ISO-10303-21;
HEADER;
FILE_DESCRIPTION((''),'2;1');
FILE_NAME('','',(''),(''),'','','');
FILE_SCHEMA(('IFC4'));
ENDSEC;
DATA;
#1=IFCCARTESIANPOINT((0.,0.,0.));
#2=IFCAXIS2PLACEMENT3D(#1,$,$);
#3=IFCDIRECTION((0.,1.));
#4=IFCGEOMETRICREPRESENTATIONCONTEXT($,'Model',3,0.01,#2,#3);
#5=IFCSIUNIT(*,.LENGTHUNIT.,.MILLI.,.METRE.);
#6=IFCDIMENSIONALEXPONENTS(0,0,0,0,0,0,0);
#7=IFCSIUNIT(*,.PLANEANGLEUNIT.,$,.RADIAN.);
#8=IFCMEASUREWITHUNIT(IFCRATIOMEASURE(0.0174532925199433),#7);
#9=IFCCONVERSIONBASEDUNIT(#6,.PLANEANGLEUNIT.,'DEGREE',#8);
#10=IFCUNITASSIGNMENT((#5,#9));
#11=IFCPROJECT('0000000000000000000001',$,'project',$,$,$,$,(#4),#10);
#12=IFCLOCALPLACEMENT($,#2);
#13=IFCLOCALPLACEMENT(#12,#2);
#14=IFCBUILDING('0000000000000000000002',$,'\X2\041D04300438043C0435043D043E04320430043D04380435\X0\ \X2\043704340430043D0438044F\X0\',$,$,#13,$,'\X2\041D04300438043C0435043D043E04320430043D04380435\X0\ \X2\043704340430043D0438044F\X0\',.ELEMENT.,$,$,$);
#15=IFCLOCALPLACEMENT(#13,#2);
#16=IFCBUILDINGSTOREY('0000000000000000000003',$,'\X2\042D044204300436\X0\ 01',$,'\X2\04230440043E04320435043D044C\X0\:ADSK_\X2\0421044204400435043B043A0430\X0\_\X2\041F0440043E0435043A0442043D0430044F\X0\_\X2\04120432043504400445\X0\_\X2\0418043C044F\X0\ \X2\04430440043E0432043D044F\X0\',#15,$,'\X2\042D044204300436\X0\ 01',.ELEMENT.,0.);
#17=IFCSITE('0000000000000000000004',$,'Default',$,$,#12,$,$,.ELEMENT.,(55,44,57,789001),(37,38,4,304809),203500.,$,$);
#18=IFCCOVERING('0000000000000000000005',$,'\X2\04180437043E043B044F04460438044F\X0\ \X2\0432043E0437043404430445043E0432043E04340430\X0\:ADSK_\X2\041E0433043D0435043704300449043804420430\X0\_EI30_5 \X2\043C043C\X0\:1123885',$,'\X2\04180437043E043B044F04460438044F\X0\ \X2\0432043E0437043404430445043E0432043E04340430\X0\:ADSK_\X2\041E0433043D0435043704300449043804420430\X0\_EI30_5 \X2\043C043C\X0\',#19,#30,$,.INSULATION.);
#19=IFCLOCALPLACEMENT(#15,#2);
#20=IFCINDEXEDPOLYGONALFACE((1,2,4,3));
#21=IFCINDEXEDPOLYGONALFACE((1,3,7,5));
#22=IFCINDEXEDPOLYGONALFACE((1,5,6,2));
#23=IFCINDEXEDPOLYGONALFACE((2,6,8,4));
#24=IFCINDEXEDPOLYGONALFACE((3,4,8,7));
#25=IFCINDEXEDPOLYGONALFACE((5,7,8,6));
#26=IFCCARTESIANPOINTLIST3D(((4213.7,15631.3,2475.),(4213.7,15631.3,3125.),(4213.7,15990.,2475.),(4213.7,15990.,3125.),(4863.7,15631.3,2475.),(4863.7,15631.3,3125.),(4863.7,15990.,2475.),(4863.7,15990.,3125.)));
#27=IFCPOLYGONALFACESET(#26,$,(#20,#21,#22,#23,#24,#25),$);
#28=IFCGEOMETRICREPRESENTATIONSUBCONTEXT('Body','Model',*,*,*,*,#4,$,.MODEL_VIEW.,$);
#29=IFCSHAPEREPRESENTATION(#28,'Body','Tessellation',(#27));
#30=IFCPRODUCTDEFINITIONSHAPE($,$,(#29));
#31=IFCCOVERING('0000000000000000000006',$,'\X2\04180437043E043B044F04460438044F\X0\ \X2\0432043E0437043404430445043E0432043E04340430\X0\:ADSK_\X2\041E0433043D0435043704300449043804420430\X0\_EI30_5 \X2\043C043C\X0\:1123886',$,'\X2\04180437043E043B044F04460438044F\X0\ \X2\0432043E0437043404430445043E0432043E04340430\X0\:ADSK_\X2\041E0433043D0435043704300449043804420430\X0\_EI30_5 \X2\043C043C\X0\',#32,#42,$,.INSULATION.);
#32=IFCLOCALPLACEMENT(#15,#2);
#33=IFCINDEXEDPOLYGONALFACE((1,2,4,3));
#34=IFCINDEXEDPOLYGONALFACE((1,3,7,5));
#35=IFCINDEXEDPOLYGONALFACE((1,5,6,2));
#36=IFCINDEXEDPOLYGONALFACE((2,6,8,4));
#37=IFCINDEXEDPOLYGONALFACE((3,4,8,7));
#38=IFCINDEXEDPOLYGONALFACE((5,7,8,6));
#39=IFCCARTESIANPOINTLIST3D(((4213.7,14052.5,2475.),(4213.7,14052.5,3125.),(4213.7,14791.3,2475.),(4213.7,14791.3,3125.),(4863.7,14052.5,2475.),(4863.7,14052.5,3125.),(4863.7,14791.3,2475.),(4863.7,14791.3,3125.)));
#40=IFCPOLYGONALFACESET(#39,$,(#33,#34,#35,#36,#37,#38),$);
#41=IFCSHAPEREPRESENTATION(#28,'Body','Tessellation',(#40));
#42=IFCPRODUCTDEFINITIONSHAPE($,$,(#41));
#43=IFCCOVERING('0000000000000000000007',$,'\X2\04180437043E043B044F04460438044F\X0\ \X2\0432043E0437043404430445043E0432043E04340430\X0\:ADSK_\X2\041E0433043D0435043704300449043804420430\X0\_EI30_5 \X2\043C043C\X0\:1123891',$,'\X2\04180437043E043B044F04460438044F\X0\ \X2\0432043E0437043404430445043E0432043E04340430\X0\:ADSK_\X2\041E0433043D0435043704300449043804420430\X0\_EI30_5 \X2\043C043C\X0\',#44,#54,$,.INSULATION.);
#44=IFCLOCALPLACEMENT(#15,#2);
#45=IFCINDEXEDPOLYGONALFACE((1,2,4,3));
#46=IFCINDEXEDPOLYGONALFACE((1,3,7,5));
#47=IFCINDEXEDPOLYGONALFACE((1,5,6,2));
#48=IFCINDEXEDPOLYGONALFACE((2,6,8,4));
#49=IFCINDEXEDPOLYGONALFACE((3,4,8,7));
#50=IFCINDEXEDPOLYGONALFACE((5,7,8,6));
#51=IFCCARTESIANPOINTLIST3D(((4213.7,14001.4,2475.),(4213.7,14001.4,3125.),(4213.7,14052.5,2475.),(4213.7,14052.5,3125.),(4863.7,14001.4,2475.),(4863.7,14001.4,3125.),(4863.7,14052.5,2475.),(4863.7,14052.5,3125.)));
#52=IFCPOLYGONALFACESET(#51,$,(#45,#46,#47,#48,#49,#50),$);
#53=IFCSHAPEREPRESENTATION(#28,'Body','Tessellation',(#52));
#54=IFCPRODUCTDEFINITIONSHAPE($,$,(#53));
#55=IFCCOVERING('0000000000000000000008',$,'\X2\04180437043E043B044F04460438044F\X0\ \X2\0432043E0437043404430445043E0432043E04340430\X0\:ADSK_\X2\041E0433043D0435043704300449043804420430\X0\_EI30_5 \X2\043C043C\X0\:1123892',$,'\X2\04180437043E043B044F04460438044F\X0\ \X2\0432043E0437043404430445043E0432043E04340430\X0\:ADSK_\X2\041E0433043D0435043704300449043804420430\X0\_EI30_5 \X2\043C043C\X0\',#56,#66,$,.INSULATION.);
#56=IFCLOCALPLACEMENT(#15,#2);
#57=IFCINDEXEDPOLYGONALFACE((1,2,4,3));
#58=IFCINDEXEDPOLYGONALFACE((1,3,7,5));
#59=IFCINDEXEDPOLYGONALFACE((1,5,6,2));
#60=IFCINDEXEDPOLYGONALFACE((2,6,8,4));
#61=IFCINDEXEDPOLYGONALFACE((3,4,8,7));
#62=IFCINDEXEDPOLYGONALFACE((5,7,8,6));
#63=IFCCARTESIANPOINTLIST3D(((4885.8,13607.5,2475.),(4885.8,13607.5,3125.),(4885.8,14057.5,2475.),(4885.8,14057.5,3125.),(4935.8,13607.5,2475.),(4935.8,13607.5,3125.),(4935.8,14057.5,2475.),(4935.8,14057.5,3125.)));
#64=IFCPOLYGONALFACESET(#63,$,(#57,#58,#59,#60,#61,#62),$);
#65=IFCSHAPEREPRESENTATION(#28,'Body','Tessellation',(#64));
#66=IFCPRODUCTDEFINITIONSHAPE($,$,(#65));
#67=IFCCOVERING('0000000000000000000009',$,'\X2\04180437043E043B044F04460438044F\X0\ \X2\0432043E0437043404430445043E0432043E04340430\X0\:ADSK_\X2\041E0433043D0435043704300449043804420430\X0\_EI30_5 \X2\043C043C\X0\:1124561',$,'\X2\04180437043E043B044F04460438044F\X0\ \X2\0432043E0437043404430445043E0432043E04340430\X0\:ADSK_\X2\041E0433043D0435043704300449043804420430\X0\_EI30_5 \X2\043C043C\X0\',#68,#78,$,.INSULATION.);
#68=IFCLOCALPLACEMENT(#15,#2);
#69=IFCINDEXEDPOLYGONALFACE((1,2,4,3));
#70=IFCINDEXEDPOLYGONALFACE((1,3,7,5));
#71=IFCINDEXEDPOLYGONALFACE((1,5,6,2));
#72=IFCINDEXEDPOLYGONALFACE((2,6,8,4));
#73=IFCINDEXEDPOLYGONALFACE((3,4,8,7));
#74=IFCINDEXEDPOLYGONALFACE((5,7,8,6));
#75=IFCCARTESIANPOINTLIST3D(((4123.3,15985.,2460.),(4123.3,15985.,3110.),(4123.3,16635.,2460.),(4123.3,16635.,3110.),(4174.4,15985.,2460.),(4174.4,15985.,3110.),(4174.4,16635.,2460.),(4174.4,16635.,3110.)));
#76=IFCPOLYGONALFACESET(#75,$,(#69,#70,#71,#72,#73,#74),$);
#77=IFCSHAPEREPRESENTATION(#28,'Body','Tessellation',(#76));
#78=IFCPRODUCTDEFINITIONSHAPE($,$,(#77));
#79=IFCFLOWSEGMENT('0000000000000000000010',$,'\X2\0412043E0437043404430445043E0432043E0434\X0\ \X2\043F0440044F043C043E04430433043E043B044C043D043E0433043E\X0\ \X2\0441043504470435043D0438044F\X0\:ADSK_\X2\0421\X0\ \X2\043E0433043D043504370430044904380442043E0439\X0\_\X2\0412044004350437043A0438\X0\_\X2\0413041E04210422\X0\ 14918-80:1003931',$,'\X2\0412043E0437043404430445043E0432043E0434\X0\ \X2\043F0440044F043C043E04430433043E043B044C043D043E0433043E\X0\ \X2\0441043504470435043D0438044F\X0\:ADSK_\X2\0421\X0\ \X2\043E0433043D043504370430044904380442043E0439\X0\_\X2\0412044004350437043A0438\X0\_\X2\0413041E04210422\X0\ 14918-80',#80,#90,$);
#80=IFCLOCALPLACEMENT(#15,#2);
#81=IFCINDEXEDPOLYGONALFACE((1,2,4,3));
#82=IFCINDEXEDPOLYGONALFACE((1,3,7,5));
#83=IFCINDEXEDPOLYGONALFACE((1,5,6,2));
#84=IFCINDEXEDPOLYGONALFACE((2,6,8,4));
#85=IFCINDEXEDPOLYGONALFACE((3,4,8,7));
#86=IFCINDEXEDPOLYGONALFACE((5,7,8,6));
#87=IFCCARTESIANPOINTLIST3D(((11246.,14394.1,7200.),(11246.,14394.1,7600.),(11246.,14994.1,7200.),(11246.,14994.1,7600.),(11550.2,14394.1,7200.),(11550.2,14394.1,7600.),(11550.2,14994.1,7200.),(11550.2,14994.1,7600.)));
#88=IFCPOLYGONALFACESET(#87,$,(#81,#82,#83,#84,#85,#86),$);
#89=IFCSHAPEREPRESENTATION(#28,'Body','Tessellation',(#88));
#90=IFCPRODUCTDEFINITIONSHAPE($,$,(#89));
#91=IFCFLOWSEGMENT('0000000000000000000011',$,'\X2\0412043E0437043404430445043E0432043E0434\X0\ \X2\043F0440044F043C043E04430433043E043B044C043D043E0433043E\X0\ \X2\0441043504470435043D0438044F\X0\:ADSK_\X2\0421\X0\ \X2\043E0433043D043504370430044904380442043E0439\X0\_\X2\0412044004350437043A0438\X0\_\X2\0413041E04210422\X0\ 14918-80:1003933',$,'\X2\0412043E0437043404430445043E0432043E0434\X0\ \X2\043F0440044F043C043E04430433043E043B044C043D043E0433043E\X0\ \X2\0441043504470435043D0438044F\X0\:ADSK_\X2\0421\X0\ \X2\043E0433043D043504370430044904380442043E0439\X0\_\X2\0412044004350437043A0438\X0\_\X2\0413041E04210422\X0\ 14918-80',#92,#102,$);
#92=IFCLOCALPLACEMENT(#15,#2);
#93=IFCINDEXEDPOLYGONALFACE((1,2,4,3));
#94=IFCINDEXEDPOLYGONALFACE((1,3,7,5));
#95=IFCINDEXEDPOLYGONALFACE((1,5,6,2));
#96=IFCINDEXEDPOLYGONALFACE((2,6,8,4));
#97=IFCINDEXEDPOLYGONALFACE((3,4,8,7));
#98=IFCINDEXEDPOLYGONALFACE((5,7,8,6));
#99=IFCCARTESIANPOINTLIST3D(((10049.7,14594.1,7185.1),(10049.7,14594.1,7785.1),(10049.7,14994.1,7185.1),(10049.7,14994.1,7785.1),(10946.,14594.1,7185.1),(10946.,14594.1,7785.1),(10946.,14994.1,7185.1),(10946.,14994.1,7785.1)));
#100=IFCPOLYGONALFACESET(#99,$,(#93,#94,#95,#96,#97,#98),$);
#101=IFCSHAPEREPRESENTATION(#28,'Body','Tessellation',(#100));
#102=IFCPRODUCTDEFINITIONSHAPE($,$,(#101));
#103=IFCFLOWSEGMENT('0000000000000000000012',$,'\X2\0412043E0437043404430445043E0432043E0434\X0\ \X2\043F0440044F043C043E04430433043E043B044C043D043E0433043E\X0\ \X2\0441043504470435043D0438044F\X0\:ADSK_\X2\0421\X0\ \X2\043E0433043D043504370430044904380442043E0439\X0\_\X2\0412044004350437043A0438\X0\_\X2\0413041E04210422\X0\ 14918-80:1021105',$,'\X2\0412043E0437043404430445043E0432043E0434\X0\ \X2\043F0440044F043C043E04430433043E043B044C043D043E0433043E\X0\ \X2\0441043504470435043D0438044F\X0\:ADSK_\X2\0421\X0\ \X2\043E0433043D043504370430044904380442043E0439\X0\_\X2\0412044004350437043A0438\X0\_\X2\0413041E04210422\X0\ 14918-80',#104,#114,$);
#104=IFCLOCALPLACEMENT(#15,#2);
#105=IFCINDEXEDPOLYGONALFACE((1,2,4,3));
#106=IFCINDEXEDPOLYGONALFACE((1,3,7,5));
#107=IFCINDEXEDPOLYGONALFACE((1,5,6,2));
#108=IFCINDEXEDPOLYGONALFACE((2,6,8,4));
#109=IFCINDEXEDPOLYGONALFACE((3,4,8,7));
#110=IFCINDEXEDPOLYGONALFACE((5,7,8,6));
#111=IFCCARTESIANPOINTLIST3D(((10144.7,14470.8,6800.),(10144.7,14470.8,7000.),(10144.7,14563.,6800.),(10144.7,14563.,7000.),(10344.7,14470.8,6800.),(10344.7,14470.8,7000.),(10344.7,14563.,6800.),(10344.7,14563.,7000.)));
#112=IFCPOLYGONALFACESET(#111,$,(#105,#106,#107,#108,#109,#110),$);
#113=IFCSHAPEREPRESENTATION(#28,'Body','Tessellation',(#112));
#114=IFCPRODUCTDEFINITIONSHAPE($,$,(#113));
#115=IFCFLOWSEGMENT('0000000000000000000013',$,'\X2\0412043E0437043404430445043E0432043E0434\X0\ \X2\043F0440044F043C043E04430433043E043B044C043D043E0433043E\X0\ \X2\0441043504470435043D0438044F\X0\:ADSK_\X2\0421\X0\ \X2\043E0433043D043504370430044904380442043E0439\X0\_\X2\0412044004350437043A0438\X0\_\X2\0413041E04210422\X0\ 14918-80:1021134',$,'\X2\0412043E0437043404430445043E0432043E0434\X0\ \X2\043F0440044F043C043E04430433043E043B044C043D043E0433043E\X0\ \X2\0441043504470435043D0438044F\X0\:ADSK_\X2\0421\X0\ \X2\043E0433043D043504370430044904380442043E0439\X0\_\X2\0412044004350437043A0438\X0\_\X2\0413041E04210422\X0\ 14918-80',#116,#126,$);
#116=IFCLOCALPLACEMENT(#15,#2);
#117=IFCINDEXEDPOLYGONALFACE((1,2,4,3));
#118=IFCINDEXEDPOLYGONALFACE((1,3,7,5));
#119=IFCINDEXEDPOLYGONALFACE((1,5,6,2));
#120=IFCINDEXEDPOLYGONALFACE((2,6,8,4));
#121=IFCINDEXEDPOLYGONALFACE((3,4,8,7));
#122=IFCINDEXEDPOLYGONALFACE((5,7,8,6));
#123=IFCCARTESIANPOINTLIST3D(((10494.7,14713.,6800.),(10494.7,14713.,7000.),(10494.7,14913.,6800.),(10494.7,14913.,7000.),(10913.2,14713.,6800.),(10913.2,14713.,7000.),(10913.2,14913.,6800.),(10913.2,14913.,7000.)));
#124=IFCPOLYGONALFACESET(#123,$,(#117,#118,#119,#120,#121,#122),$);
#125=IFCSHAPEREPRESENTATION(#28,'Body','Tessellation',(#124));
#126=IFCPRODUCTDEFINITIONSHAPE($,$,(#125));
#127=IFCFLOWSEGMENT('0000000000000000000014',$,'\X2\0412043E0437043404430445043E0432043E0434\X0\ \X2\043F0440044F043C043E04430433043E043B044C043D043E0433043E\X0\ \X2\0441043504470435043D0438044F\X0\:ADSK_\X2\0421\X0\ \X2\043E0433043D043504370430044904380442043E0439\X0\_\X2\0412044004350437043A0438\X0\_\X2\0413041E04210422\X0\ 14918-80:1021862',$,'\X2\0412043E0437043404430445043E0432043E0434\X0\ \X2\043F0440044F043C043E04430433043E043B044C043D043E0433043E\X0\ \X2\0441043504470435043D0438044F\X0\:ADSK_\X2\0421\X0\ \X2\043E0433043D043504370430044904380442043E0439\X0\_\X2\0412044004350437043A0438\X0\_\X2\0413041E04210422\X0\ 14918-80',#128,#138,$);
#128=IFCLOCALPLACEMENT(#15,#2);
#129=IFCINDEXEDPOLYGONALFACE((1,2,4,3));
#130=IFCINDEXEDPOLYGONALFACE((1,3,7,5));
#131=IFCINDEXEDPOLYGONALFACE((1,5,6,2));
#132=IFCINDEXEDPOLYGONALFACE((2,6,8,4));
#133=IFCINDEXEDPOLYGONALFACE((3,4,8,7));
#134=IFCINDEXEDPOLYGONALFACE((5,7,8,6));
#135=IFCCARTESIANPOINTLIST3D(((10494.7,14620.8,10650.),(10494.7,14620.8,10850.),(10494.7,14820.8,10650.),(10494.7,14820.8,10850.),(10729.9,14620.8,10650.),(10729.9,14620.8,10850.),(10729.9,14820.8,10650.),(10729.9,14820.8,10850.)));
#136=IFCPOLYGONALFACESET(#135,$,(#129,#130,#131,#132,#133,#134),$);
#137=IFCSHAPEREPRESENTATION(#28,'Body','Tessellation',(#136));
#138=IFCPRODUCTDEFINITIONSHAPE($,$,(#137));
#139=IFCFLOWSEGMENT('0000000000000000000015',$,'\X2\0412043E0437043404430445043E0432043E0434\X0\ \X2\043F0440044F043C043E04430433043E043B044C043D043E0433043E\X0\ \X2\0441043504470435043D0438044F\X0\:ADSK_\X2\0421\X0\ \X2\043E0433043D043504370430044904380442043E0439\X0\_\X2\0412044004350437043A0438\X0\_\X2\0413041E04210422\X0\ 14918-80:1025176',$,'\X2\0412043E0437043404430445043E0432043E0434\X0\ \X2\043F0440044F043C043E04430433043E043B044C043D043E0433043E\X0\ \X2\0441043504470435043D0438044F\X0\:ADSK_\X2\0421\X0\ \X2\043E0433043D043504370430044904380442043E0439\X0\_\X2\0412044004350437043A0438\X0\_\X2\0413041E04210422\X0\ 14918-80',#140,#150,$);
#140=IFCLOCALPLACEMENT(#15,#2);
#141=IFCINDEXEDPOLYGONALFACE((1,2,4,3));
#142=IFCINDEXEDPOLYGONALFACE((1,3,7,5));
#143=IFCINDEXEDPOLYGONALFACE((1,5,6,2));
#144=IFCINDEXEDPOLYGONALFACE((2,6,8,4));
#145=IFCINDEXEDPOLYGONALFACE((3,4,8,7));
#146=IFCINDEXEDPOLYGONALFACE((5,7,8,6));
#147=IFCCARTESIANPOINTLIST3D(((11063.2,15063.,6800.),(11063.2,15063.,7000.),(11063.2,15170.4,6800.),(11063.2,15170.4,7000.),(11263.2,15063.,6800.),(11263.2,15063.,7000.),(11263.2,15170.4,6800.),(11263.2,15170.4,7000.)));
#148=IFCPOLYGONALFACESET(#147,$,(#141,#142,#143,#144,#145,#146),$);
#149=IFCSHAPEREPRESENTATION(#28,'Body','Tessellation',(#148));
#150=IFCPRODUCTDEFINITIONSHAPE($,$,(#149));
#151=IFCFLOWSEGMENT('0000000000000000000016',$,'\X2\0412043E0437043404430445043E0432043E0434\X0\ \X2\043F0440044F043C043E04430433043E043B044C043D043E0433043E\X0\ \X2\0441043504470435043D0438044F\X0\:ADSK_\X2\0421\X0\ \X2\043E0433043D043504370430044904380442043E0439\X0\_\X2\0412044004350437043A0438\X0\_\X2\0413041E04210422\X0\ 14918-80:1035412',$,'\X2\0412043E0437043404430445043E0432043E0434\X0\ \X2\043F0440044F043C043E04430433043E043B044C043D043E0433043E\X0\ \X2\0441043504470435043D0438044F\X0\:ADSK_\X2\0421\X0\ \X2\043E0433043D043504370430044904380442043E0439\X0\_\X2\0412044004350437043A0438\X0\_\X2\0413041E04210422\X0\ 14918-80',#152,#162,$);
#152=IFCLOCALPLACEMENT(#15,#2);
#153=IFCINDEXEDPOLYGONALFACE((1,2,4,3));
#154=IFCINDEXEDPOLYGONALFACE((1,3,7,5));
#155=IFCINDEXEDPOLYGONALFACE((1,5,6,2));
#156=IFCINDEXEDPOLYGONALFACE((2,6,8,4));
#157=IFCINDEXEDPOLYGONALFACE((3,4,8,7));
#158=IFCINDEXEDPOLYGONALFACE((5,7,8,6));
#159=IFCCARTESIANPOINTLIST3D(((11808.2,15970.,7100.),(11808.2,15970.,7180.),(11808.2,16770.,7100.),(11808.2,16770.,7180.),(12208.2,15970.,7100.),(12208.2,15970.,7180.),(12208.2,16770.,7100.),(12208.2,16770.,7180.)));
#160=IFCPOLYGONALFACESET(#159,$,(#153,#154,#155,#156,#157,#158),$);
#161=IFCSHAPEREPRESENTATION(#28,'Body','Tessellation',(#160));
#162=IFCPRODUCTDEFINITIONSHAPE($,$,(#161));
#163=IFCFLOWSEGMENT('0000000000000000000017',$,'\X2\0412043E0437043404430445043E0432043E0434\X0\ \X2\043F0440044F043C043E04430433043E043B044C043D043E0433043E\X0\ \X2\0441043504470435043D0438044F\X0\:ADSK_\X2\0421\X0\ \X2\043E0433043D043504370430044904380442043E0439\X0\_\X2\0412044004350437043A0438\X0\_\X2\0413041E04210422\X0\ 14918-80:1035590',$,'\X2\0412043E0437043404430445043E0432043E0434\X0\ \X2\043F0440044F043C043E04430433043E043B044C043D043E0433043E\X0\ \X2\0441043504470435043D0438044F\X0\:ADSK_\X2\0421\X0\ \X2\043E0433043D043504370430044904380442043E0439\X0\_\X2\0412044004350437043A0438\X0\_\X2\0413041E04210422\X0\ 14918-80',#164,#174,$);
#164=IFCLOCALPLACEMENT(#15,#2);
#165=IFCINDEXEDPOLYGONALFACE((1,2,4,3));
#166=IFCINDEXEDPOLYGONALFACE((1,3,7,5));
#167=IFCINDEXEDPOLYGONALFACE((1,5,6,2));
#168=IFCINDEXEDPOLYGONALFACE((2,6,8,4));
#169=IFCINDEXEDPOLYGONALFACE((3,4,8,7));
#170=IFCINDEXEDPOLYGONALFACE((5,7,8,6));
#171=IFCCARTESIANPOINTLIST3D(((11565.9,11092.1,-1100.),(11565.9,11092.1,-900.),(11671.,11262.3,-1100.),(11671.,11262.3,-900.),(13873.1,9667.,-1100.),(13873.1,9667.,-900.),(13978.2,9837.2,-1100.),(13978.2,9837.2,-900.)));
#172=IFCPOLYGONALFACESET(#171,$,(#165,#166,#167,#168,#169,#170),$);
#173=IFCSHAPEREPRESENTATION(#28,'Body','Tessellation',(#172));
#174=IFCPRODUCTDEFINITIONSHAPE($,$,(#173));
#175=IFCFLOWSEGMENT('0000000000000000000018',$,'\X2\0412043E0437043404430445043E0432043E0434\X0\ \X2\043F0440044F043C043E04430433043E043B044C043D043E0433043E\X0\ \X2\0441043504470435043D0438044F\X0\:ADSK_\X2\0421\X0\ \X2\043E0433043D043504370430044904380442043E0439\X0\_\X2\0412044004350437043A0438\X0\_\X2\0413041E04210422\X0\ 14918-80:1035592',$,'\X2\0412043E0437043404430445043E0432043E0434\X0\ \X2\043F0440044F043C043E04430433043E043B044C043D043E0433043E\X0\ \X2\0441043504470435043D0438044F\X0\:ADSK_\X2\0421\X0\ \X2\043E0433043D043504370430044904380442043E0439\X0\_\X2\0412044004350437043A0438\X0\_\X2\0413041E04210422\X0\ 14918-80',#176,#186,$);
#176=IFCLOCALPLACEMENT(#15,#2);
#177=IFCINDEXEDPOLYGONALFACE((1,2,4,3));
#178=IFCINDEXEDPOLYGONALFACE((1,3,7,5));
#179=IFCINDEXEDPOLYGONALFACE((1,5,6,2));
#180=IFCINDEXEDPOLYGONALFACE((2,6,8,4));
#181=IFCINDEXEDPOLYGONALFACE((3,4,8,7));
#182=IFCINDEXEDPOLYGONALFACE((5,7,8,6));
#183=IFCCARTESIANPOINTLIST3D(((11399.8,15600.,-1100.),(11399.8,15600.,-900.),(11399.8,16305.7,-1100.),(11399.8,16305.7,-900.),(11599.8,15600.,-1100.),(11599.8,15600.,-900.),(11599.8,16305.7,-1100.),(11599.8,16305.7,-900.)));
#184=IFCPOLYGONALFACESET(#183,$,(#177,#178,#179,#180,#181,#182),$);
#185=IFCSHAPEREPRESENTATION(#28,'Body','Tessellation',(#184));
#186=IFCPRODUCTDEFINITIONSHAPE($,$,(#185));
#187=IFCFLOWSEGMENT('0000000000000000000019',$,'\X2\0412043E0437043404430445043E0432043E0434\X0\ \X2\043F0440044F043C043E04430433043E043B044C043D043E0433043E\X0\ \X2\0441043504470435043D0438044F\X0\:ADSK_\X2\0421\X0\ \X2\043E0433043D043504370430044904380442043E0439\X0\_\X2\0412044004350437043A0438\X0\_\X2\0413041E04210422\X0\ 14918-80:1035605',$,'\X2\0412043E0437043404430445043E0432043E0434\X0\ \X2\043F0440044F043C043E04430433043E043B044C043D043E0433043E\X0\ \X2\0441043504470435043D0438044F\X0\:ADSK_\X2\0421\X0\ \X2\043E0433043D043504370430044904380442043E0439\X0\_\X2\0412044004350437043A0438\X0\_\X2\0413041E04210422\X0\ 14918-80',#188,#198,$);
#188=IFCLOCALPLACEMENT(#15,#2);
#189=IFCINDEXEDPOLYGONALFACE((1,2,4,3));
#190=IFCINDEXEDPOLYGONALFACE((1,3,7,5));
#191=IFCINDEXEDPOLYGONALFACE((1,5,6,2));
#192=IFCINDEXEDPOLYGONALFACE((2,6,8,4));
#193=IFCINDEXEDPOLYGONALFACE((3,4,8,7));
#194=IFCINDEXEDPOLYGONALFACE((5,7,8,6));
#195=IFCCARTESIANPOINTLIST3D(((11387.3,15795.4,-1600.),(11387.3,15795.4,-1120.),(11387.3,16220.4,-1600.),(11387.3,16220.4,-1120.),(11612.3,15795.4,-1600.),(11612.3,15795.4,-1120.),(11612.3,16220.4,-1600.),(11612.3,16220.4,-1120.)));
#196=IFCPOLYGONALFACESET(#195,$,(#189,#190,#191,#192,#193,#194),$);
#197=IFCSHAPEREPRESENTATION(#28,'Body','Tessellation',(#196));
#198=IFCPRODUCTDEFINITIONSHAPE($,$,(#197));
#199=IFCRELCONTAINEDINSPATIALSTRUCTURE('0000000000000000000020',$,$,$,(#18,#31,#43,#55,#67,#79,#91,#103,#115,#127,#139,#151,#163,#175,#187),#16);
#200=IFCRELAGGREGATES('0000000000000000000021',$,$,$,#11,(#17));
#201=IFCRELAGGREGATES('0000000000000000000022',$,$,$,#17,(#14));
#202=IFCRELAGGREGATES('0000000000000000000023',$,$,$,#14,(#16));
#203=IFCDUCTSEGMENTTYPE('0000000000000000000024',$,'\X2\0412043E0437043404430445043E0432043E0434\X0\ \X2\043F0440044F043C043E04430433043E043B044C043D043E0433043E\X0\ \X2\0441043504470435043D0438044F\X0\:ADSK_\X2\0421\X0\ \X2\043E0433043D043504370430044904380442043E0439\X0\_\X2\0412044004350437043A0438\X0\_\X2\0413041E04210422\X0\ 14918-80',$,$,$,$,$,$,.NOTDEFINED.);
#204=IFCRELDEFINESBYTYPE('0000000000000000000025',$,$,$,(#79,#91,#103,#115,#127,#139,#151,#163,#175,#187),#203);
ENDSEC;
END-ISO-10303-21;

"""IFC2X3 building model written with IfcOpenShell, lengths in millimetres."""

from ifc_helpers import new_model, entity, si_unit, converted_unit, direction, frame, frame_2d, origin, origin_2d_with_axis, place, context, subcontext, project, spatial, rectangle, extrude, type_object, element, save


model = new_model("IFC2X3")

# Units and contexts
model_context = context("Model", 3, precision=0.01, world=origin(), true_north=direction((0.0, 1.0)))
body_context = subcontext(model_context, "Body", "Model", "MODEL_VIEW")
ifc_project = project(units=[si_unit("LENGTHUNIT", "METRE", prefix="MILLI"), converted_unit("PLANEANGLEUNIT", "DEGREE", entity("IfcRatioMeasure", 0.0174532925199433), si_unit("PLANEANGLEUNIT", "RADIAN"), dimensions=[0, 0, 0, 0, 0, 0, 0])], contexts=[model_context])

# Site, building, storey
site_placement = place(None, frame((0.0, 0.0, 0.0)))
site = spatial("IfcSite", under=ifc_project, at=site_placement, Name="Default", CompositionType="ELEMENT", RefLatitude=(55, 44, 57, 789001), RefLongitude=(37, 38, 4, 304809), RefElevation=203500.0)
building_placement = place(site_placement, origin())
building = spatial("IfcBuilding", under=site, at=building_placement, Name="Наименование здания", LongName="Наименование здания", CompositionType="ELEMENT")
storey_placement = place(building_placement, origin())
storey = spatial("IfcBuildingStorey", under=building, at=storey_placement, Name="Этаж 01", ObjectType="Уровень:ADSK_Стрелка_Проектная_Вверх_Имя уровня", LongName="Этаж 01", CompositionType="ELEMENT", Elevation=0.0)

# Coverings
covering_1_placement = place(storey_placement, frame((4213.7, 15631.3, 2475.0)))
element("IfcCovering", 1, at=covering_1_placement, inside=storey, Name="Изоляция воздуховода:ADSK_Огнезащита_EI30_5 мм:1123885", ObjectType="Изоляция воздуховода:ADSK_Огнезащита_EI30_5 мм", PredefinedType="INSULATION", context=body_context, shape_type="SweptSolid", body=[
    extrude(rectangle(XDim=358.6, YDim=650.0, at=origin_2d_with_axis()), frame((325.0, 179.3, 0.0), z_axis=(0.0, 0.0, 1.0), x_axis=(0.0, 1.0, 0.0)), (0.0, 0.0, 1.0), 650.0),
])
covering_2_placement = place(storey_placement, frame((4213.7, 14052.5, 2475.0)))
element("IfcCovering", 2, at=covering_2_placement, inside=storey, Name="Изоляция воздуховода:ADSK_Огнезащита_EI30_5 мм:1123886", ObjectType="Изоляция воздуховода:ADSK_Огнезащита_EI30_5 мм", PredefinedType="INSULATION", context=body_context, shape_type="SweptSolid", body=[
    extrude(rectangle(XDim=738.8, YDim=650.0, at=origin_2d_with_axis()), frame((325.0, 369.4, 0.0), z_axis=(0.0, 0.0, 1.0), x_axis=(0.0, -1.0, 0.0)), (0.0, 0.0, 1.0), 650.0),
])
covering_3_placement = place(storey_placement, frame((4213.7, 14001.4, 2475.0)))
element("IfcCovering", 3, at=covering_3_placement, inside=storey, Name="Изоляция воздуховода:ADSK_Огнезащита_EI30_5 мм:1123891", ObjectType="Изоляция воздуховода:ADSK_Огнезащита_EI30_5 мм", PredefinedType="INSULATION", context=body_context, shape_type="SweptSolid", body=[
    extrude(rectangle(XDim=650.0, YDim=51.1, at=frame_2d((0.0, 0.0), x_axis=(1.0, 0.0))), frame((325.0, 25.5, 0.0), z_axis=(0.0, 0.0, 1.0), x_axis=(-1.0, 0.0, 0.0)), (0.0, 0.0, 1.0), 650.0),
])
covering_4_placement = place(storey_placement, frame((4885.8, 13607.5, 2475.0)))
element("IfcCovering", 4, at=covering_4_placement, inside=storey, Name="Изоляция воздуховода:ADSK_Огнезащита_EI30_5 мм:1123892", ObjectType="Изоляция воздуховода:ADSK_Огнезащита_EI30_5 мм", PredefinedType="INSULATION", context=body_context, shape_type="SweptSolid", body=[
    extrude(rectangle(XDim=50.0, YDim=450.0, at=frame_2d((0.0, 0.0), x_axis=(1.0, 0.0))), frame((25.0, 225.0, 0.0), z_axis=(0.0, 0.0, 1.0), x_axis=(-1.0, 0.0, 0.0)), (0.0, 0.0, 1.0), 650.0),
])
covering_5_placement = place(storey_placement, frame((4123.3, 15985.0, 2460.0)))
element("IfcCovering", 5, at=covering_5_placement, inside=storey, Name="Изоляция воздуховода:ADSK_Огнезащита_EI30_5 мм:1124561", ObjectType="Изоляция воздуховода:ADSK_Огнезащита_EI30_5 мм", PredefinedType="INSULATION", context=body_context, shape_type="SweptSolid", body=[
    extrude(rectangle(XDim=650.0, YDim=51.1, at=frame_2d((0.0, 0.0), x_axis=(1.0, 0.0))), frame((25.5, 325.0, 0.0), z_axis=(0.0, 0.0, 1.0), x_axis=(0.0, -1.0, 0.0)), (0.0, 0.0, 1.0), 650.0),
])

# Flow segments
duct_segment_type_1 = type_object("IfcDuctSegmentType", Name="Воздуховод прямоугольного сечения:ADSK_С огнезащитой_Врезки_ГОСТ 14918-80", PredefinedType="NOTDEFINED")
flow_segment_1_placement = place(storey_placement, frame((11246.0, 14394.1, 7200.0)))
element("IfcFlowSegment", 6, at=flow_segment_1_placement, inside=storey, type_object=duct_segment_type_1, Name="Воздуховод прямоугольного сечения:ADSK_С огнезащитой_Врезки_ГОСТ 14918-80:1003931", ObjectType="Воздуховод прямоугольного сечения:ADSK_С огнезащитой_Врезки_ГОСТ 14918-80", context=body_context, shape_type="SweptSolid", body=[
    extrude(rectangle(XDim=304.2, YDim=600.0, at=frame_2d((0.0, 0.0), x_axis=(1.0, 0.0))), frame((152.1, 300.0, 0.0), z_axis=(0.0, 0.0, 1.0), x_axis=(-1.0, 0.0, 0.0)), (0.0, 0.0, 1.0), 400.0),
])
flow_segment_2_placement = place(storey_placement, frame((10049.7, 14594.1, 7185.1)))
element("IfcFlowSegment", 7, at=flow_segment_2_placement, inside=storey, type_object=duct_segment_type_1, Name="Воздуховод прямоугольного сечения:ADSK_С огнезащитой_Врезки_ГОСТ 14918-80:1003933", ObjectType="Воздуховод прямоугольного сечения:ADSK_С огнезащитой_Врезки_ГОСТ 14918-80", context=body_context, shape_type="SweptSolid", body=[
    extrude(rectangle(XDim=896.3, YDim=400.0, at=origin_2d_with_axis()), frame((448.1, 200.0, 0.0), z_axis=(0.0, 0.0, 1.0), x_axis=(-1.0, 0.0, 0.0)), (0.0, 0.0, 1.0), 600.0),
])
flow_segment_3_placement = place(storey_placement, frame((10144.7, 14470.8, 6800.0)))
element("IfcFlowSegment", 8, at=flow_segment_3_placement, inside=storey, type_object=duct_segment_type_1, Name="Воздуховод прямоугольного сечения:ADSK_С огнезащитой_Врезки_ГОСТ 14918-80:1021105", ObjectType="Воздуховод прямоугольного сечения:ADSK_С огнезащитой_Врезки_ГОСТ 14918-80", context=body_context, shape_type="SweptSolid", body=[
    extrude(rectangle(XDim=92.2, YDim=200.0, at=frame_2d((0.0, 0.0), x_axis=(1.0, 0.0))), frame((100.0, 46.1, 0.0), z_axis=(0.0, 0.0, 1.0), x_axis=(0.0, 1.0, 0.0)), (0.0, 0.0, 1.0), 200.0),
])
flow_segment_4_placement = place(storey_placement, frame((10494.7, 14713.0, 6800.0)))
element("IfcFlowSegment", 9, at=flow_segment_4_placement, inside=storey, type_object=duct_segment_type_1, Name="Воздуховод прямоугольного сечения:ADSK_С огнезащитой_Врезки_ГОСТ 14918-80:1021134", ObjectType="Воздуховод прямоугольного сечения:ADSK_С огнезащитой_Врезки_ГОСТ 14918-80", context=body_context, shape_type="SweptSolid", body=[
    extrude(rectangle(XDim=418.5, YDim=200.0, at=frame_2d((0.0, 0.0), x_axis=(1.0, 0.0))), frame((209.3, 100.0, 0.0)), (0.0, 0.0, 1.0), 200.0),
])
flow_segment_5_placement = place(storey_placement, frame((10494.7, 14620.8, 10650.0)))
element("IfcFlowSegment", 10, at=flow_segment_5_placement, inside=storey, type_object=duct_segment_type_1, Name="Воздуховод прямоугольного сечения:ADSK_С огнезащитой_Врезки_ГОСТ 14918-80:1021862", ObjectType="Воздуховод прямоугольного сечения:ADSK_С огнезащитой_Врезки_ГОСТ 14918-80", context=body_context, shape_type="SweptSolid", body=[
    extrude(rectangle(XDim=235.2, YDim=200.0, at=frame_2d((0.0, 0.0), x_axis=(1.0, 0.0))), frame((117.6, 100.0, 0.0), z_axis=(0.0, 0.0, 1.0), x_axis=(-1.0, 0.0, 0.0)), (0.0, 0.0, 1.0), 200.0),
])
flow_segment_6_placement = place(storey_placement, frame((11063.2, 15063.0, 6800.0)))
element("IfcFlowSegment", 11, at=flow_segment_6_placement, inside=storey, type_object=duct_segment_type_1, Name="Воздуховод прямоугольного сечения:ADSK_С огнезащитой_Врезки_ГОСТ 14918-80:1025176", ObjectType="Воздуховод прямоугольного сечения:ADSK_С огнезащитой_Врезки_ГОСТ 14918-80", context=body_context, shape_type="SweptSolid", body=[
    extrude(rectangle(XDim=107.3, YDim=200.0, at=frame_2d((0.0, 0.0), x_axis=(1.0, 0.0))), frame((100.0, 53.7, 0.0), z_axis=(0.0, 0.0, 1.0), x_axis=(0.0, 1.0, 0.0)), (0.0, 0.0, 1.0), 200.0),
])
flow_segment_7_placement = place(storey_placement, frame((11808.2, 15970.0, 7100.0)))
element("IfcFlowSegment", 12, at=flow_segment_7_placement, inside=storey, type_object=duct_segment_type_1, Name="Воздуховод прямоугольного сечения:ADSK_С огнезащитой_Врезки_ГОСТ 14918-80:1035412", ObjectType="Воздуховод прямоугольного сечения:ADSK_С огнезащитой_Врезки_ГОСТ 14918-80", context=body_context, shape_type="SweptSolid", body=[
    extrude(rectangle(XDim=800.0, YDim=400.0, at=origin_2d_with_axis()), frame((200.0, 400.0, 0.0), z_axis=(0.0, 0.0, 1.0), x_axis=(0.0, 1.0, 0.0)), (0.0, 0.0, 1.0), 80.0),
])
flow_segment_8_placement = place(storey_placement, frame((11565.9, 9667.0, -1100.0)))
element("IfcFlowSegment", 13, at=flow_segment_8_placement, inside=storey, type_object=duct_segment_type_1, Name="Воздуховод прямоугольного сечения:ADSK_С огнезащитой_Врезки_ГОСТ 14918-80:1035590", ObjectType="Воздуховод прямоугольного сечения:ADSK_С огнезащитой_Врезки_ГОСТ 14918-80", context=body_context, shape_type="SweptSolid", body=[
    extrude(rectangle(XDim=2711.9, YDim=200.0, at=frame_2d((0.0, 0.0), x_axis=(1.0, 0.0))), frame((1206.2, 797.6, 0.0), z_axis=(0.0, 0.0, 1.0), x_axis=(0.850783, -0.525517, 0.0)), (0.0, 0.0, 1.0), 200.0),
])
flow_segment_9_placement = place(storey_placement, frame((11399.8, 15600.0, -1100.0)))
element("IfcFlowSegment", 14, at=flow_segment_9_placement, inside=storey, type_object=duct_segment_type_1, Name="Воздуховод прямоугольного сечения:ADSK_С огнезащитой_Врезки_ГОСТ 14918-80:1035592", ObjectType="Воздуховод прямоугольного сечения:ADSK_С огнезащитой_Врезки_ГОСТ 14918-80", context=body_context, shape_type="SweptSolid", body=[
    extrude(rectangle(XDim=705.7, YDim=200.0, at=frame_2d((0.0, 0.0), x_axis=(1.0, 0.0))), frame((100.0, 352.8, 0.0), z_axis=(0.0, 0.0, 1.0), x_axis=(0.0, 1.0, 0.0)), (0.0, 0.0, 1.0), 200.0),
])
flow_segment_10_placement = place(storey_placement, frame((11387.3, 15795.4, -1600.0)))
element("IfcFlowSegment", 15, at=flow_segment_10_placement, inside=storey, type_object=duct_segment_type_1, Name="Воздуховод прямоугольного сечения:ADSK_С огнезащитой_Врезки_ГОСТ 14918-80:1035605", ObjectType="Воздуховод прямоугольного сечения:ADSK_С огнезащитой_Врезки_ГОСТ 14918-80", context=body_context, shape_type="SweptSolid", body=[
    extrude(rectangle(XDim=225.0, YDim=425.0, at=frame_2d((0.0, 0.0), x_axis=(1.0, 0.0))), frame((112.5, 212.5, 0.0), z_axis=(0.0, 0.0, 1.0), x_axis=(-1.0, 0.0, 0.0)), (0.0, 0.0, 1.0), 480.0),
])

save(model, "model.ifc")
